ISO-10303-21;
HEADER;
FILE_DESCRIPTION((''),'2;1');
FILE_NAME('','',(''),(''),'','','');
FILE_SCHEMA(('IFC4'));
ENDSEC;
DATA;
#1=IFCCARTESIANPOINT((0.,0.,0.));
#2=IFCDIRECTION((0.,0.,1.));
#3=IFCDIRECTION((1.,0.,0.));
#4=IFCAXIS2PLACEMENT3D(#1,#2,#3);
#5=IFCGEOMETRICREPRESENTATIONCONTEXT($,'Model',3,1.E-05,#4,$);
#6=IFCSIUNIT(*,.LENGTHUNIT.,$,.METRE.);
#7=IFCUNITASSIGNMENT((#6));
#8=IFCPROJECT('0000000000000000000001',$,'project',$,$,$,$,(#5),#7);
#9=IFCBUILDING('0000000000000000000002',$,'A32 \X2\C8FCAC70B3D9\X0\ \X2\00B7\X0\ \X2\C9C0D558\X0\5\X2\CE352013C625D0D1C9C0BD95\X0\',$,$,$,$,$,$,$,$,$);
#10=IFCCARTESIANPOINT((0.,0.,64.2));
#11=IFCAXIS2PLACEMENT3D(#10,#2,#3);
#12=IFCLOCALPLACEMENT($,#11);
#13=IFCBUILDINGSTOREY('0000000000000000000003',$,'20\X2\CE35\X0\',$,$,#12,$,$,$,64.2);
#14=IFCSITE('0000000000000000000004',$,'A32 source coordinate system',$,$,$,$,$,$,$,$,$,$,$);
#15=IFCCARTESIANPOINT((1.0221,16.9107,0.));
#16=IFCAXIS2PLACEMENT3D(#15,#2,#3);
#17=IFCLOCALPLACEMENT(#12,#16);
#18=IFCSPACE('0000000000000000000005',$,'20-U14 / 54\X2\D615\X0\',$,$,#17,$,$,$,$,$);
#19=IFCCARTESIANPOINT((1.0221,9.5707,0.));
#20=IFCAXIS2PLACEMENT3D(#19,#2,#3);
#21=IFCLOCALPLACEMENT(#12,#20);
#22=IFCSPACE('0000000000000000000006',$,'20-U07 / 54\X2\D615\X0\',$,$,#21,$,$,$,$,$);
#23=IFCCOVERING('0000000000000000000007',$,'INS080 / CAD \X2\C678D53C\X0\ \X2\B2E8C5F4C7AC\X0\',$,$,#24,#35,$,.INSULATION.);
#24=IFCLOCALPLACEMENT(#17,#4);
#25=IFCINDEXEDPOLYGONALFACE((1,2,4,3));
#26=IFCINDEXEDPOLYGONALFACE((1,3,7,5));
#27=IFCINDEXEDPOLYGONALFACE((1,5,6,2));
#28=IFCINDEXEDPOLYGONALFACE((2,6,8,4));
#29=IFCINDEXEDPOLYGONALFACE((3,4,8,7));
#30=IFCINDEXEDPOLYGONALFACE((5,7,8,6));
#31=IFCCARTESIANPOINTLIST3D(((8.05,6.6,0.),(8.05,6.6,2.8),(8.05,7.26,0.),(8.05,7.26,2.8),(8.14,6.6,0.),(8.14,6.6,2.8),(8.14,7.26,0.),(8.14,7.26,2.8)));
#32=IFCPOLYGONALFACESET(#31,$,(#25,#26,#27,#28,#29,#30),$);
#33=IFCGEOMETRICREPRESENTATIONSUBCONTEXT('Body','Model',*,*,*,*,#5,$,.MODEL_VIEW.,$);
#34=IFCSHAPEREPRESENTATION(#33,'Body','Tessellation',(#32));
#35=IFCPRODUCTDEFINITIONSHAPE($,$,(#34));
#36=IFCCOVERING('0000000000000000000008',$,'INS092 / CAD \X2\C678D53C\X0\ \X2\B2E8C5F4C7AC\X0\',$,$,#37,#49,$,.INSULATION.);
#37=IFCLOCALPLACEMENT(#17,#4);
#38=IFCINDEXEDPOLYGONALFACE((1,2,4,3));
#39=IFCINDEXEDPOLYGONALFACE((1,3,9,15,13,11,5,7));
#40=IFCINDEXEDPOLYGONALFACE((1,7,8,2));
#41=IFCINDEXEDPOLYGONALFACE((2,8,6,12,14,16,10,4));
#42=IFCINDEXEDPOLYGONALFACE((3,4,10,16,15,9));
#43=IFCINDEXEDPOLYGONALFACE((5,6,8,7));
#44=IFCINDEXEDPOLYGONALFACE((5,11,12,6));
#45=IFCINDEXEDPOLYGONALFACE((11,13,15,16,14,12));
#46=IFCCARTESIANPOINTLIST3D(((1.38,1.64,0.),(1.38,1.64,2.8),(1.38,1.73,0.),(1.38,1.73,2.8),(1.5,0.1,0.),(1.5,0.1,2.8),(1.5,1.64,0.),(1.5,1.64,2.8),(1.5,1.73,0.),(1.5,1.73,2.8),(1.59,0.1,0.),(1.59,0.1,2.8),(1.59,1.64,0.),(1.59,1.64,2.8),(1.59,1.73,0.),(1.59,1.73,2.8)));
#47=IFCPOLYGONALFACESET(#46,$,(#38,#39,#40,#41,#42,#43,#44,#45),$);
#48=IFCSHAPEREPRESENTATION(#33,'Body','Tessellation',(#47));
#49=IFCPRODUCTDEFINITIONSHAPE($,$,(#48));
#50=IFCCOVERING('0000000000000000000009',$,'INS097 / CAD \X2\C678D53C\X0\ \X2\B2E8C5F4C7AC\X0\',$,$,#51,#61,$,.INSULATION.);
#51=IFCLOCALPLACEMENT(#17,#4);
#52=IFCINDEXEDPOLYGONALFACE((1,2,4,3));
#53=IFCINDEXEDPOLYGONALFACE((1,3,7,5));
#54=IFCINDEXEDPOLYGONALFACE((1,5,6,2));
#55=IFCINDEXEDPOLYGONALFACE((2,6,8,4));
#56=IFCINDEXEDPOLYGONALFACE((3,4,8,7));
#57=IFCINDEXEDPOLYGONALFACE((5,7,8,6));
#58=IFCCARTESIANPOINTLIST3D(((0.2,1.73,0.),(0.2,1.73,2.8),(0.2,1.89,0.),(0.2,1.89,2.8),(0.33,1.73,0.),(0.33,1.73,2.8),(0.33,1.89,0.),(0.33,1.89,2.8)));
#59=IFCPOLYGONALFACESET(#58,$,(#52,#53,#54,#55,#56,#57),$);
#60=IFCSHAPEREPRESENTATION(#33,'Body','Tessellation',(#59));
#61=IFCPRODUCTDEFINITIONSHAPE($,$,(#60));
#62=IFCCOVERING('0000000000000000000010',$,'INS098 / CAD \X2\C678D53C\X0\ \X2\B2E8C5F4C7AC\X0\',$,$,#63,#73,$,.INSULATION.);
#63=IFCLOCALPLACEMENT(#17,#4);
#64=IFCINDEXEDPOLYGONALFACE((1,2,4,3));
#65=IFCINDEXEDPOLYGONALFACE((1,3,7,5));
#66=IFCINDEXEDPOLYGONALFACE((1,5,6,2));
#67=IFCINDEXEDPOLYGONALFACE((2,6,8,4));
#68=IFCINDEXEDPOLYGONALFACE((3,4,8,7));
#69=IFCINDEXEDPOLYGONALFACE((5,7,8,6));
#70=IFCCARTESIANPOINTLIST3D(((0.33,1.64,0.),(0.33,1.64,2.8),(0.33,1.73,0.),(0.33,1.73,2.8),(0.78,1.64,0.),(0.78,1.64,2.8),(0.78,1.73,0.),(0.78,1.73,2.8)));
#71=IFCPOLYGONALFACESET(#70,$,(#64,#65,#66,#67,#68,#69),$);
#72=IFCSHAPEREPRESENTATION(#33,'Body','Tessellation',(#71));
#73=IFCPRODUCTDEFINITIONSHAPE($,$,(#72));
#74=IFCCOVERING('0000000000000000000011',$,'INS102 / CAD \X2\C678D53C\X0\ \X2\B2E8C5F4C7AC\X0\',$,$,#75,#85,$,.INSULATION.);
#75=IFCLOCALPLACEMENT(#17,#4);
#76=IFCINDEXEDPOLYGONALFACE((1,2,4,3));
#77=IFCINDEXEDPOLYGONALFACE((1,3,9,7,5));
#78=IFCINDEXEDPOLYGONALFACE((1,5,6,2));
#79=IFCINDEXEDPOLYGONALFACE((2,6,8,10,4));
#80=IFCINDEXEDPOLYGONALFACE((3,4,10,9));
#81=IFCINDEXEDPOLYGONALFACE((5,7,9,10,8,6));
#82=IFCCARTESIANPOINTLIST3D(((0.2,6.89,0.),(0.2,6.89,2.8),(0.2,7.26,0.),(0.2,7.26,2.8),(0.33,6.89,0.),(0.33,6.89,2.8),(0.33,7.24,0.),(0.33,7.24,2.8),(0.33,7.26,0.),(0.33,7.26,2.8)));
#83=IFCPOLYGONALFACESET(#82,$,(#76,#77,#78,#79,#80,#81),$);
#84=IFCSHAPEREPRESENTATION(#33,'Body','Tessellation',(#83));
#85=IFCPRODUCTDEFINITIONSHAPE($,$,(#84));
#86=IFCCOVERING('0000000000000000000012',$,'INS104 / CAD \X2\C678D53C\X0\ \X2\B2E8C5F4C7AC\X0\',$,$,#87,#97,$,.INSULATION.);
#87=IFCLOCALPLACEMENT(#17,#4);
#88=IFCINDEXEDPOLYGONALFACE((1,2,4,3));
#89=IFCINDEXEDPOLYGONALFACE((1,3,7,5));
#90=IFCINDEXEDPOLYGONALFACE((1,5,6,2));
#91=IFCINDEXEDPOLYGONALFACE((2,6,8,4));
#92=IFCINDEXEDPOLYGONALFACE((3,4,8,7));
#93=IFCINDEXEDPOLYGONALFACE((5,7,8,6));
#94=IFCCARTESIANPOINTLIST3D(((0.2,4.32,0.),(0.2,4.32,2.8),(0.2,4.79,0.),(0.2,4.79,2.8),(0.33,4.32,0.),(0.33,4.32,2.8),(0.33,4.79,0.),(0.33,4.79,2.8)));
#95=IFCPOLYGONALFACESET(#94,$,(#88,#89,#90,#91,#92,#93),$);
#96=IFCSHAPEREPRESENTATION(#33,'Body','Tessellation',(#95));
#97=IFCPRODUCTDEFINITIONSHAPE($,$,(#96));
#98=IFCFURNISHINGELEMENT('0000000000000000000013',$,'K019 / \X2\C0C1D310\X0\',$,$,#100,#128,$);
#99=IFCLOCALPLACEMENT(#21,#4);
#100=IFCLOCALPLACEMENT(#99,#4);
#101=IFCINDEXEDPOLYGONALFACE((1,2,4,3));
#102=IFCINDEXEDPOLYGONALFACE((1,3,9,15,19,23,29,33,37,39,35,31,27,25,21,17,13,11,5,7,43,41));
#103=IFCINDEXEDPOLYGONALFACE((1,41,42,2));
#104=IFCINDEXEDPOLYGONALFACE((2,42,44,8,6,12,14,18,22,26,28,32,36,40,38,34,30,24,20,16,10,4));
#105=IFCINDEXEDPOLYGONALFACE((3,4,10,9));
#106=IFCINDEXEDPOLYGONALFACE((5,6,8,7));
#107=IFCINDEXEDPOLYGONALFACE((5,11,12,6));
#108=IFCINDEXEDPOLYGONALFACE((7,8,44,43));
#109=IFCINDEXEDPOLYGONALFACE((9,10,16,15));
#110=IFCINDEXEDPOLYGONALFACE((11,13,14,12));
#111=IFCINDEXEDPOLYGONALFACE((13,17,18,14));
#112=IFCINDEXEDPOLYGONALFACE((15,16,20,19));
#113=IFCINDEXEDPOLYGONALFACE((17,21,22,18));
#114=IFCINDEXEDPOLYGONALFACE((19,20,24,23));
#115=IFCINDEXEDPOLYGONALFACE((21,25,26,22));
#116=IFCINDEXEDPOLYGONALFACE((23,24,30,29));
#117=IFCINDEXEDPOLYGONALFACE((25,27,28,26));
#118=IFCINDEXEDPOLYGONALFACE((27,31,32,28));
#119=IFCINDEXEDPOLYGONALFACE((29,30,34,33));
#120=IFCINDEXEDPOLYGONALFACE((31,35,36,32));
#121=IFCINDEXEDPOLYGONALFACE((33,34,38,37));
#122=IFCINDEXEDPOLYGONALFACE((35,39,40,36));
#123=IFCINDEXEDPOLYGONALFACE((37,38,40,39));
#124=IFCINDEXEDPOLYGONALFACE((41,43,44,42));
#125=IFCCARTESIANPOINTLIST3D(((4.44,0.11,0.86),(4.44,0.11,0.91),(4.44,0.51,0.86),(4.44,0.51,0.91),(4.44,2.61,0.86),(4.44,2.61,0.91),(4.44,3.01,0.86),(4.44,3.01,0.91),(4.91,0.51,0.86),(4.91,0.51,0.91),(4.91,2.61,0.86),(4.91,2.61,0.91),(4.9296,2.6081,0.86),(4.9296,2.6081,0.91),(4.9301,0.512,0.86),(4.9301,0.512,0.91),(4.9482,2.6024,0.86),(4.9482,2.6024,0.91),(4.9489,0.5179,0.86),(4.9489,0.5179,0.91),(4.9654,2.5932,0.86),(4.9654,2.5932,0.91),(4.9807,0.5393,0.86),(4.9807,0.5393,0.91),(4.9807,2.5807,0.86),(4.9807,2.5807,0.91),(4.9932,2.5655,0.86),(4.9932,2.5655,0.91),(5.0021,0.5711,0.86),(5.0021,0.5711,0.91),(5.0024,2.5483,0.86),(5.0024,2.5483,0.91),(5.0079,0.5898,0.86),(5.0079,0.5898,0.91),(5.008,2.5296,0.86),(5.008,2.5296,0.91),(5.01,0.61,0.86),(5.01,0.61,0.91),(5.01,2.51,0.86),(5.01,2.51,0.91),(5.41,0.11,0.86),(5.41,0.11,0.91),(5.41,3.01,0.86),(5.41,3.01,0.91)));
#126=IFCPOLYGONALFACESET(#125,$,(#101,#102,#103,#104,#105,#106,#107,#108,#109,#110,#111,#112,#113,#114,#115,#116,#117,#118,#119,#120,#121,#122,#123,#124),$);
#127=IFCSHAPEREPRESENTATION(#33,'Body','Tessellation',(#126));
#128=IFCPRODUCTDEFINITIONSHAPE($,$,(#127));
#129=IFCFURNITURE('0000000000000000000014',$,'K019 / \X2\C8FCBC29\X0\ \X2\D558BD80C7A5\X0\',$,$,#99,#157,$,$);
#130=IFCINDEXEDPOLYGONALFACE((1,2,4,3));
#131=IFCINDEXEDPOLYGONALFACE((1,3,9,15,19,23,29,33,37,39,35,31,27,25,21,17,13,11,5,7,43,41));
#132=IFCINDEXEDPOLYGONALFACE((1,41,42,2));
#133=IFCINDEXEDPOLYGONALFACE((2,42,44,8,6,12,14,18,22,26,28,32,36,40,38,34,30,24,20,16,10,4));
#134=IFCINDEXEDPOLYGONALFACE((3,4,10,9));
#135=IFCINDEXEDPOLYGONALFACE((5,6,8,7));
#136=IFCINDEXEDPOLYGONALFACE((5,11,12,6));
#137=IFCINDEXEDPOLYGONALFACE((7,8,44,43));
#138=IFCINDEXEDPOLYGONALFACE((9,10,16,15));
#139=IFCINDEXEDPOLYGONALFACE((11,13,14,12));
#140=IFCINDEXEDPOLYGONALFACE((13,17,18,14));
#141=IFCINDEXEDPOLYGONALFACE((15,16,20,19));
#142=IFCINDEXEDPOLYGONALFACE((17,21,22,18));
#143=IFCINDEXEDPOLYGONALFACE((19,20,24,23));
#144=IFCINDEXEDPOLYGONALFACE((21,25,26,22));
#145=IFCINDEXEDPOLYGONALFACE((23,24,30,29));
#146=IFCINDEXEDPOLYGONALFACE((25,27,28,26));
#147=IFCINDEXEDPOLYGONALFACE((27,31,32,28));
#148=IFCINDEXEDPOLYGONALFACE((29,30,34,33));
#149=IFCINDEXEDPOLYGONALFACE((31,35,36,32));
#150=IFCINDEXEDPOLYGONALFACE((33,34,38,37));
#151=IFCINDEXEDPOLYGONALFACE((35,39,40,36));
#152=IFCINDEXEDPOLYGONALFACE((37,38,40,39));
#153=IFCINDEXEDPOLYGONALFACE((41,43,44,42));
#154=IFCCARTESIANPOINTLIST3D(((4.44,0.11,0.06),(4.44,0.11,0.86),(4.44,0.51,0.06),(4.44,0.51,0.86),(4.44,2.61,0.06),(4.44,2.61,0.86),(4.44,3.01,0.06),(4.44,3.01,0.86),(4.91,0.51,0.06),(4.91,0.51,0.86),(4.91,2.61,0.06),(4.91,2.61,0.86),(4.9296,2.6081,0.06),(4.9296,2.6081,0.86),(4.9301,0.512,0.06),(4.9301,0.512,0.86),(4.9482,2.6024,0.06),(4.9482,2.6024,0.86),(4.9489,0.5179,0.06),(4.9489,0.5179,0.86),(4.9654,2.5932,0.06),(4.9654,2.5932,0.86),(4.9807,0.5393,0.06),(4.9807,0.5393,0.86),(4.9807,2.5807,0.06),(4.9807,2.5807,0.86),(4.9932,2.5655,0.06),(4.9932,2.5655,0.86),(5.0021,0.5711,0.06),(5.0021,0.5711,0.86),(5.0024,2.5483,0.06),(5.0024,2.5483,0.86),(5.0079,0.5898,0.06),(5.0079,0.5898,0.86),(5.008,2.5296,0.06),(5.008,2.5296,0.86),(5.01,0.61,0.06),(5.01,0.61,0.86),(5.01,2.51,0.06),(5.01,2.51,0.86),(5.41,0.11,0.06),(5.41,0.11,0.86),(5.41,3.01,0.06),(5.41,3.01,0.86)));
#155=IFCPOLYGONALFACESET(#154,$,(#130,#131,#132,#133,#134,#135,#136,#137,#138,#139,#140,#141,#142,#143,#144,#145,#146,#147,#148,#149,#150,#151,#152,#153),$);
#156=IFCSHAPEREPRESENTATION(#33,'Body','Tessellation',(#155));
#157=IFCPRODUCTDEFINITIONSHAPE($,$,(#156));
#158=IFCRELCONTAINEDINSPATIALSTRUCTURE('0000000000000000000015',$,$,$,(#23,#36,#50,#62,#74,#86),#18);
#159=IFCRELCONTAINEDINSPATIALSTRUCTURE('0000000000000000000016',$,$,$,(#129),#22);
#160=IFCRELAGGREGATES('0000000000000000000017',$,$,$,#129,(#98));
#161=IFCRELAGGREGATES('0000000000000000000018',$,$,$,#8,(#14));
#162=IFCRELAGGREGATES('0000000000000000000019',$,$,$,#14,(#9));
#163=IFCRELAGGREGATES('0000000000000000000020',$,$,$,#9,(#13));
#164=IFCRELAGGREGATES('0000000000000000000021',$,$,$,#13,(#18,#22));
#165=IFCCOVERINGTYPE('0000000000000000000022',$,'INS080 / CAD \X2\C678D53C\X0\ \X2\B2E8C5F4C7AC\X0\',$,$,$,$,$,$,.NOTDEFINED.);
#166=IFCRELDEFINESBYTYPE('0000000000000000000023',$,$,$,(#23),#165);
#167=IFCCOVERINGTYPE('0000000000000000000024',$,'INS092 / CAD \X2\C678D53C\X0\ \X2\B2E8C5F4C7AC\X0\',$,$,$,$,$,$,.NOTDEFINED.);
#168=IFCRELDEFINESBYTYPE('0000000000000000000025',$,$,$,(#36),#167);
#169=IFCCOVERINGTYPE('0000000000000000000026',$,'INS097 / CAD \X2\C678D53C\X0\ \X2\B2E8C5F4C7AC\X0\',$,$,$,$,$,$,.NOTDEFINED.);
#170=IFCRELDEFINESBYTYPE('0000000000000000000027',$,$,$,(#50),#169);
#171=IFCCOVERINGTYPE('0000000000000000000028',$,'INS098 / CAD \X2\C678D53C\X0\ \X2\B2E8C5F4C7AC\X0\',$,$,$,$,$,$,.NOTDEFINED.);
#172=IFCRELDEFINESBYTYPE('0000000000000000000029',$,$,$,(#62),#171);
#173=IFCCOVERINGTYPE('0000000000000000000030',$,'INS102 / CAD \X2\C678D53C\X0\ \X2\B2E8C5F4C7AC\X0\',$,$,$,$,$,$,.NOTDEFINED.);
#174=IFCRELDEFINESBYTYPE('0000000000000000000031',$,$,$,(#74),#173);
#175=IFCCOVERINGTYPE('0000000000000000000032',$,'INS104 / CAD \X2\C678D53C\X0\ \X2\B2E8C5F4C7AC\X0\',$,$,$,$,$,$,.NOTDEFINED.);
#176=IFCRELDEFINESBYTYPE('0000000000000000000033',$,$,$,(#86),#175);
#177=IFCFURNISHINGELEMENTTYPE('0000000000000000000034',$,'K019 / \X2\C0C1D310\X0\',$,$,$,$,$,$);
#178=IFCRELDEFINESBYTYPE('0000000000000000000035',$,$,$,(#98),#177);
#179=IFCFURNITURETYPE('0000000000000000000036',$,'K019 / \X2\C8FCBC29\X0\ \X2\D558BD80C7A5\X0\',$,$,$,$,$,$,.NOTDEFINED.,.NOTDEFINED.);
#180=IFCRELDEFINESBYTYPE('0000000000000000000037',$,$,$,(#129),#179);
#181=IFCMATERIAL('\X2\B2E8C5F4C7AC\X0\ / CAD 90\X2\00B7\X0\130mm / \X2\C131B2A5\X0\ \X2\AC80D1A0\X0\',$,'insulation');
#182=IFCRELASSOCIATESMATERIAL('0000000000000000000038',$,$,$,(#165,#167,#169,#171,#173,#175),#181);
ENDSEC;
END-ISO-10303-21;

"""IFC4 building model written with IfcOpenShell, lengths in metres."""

from ifc_helpers import new_model, si_unit, frame, origin, origin_with_axes, place, context, subcontext, project, spatial, polyline, outline, extrude, source, transform, mapped, material, type_object, type_shapes, element, aggregate, save


model = new_model("IFC4")

# Units and contexts
model_context = context("Model", 3, precision=1e-05, world=origin_with_axes())
body_context = subcontext(model_context, "Body", "Model", "MODEL_VIEW")
ifc_project = project(units=[si_unit("LENGTHUNIT", "METRE")], contexts=[model_context])

# Site, building, storey, space
storey_placement = place(None, frame((0.0, 0.0, 64.2), z_axis=(0.0, 0.0, 1.0), x_axis=(1.0, 0.0, 0.0)))
space_1_placement = place(storey_placement, frame((1.0221, 16.9107, 0.0), z_axis=(0.0, 0.0, 1.0), x_axis=(1.0, 0.0, 0.0)))
site = spatial("IfcSite", under=ifc_project, Name="A32 source coordinate system")
building = spatial("IfcBuilding", under=site, Name="A32 주거동 · 지하5층–옥탑지붕")
storey = spatial("IfcBuildingStorey", under=building, at=storey_placement, Name="20층", Elevation=64.2)
space_1 = spatial("IfcSpace", under=storey, at=space_1_placement, Name="20-U14 / 54형")

# Coverings
ifc_material = material(Name="단열재 / CAD 90·130mm / 성능 검토", Category="insulation")
covering_type_1 = type_object("IfcCoveringType", Name="INS080 / CAD 외피 단열재", PredefinedType="NOTDEFINED", material=ifc_material)
shared_shape_1 = source(origin(), body_context, "Body", "SweptSolid", [
    extrude(outline(polyline([(8.14, 7.26), (8.14, 6.6), (8.05, 6.6), (8.05, 7.26), (8.14, 7.26)])), origin(), (0.0, 0.0, 1.0), 2.8),
])
type_shapes(covering_type_1, [shared_shape_1])
covering_1_placement = place(space_1_placement, origin_with_axes())
element("IfcCovering", 1, at=covering_1_placement, inside=space_1, type_object=covering_type_1, Name="INS080 / CAD 외피 단열재", PredefinedType="INSULATION", context=body_context, shape_type="MappedRepresentation", body=[
    mapped(shared_shape_1, transform((0.0, 0.0, 0.0), scale=1.0)),
])
covering_type_2 = type_object("IfcCoveringType", Name="INS092 / CAD 외피 단열재", PredefinedType="NOTDEFINED", material=ifc_material)
shared_shape_2 = source(origin(), body_context, "Body", "SweptSolid", [
    extrude(outline(polyline([(1.59, 1.73), (1.59, 1.64), (1.59, 0.1), (1.5, 0.1), (1.5, 1.64), (1.38, 1.64), (1.38, 1.73), (1.5, 1.73), (1.59, 1.73)])), origin(), (0.0, 0.0, 1.0), 2.8),
])
type_shapes(covering_type_2, [shared_shape_2])
covering_2_placement = place(space_1_placement, origin_with_axes())
element("IfcCovering", 2, at=covering_2_placement, inside=space_1, type_object=covering_type_2, Name="INS092 / CAD 외피 단열재", PredefinedType="INSULATION", context=body_context, shape_type="MappedRepresentation", body=[
    mapped(shared_shape_2, transform((0.0, 0.0, 0.0), scale=1.0)),
])
covering_type_3 = type_object("IfcCoveringType", Name="INS097 / CAD 외피 단열재", PredefinedType="NOTDEFINED", material=ifc_material)
shared_shape_3 = source(origin(), body_context, "Body", "SweptSolid", [
    extrude(outline(polyline([(0.33, 1.89), (0.33, 1.73), (0.2, 1.73), (0.2, 1.89), (0.33, 1.89)])), origin(), (0.0, 0.0, 1.0), 2.8),
])
type_shapes(covering_type_3, [shared_shape_3])
covering_3_placement = place(space_1_placement, origin_with_axes())
element("IfcCovering", 3, at=covering_3_placement, inside=space_1, type_object=covering_type_3, Name="INS097 / CAD 외피 단열재", PredefinedType="INSULATION", context=body_context, shape_type="MappedRepresentation", body=[
    mapped(shared_shape_3, transform((0.0, 0.0, 0.0), scale=1.0)),
])
covering_type_4 = type_object("IfcCoveringType", Name="INS098 / CAD 외피 단열재", PredefinedType="NOTDEFINED", material=ifc_material)
shared_shape_4 = source(origin(), body_context, "Body", "SweptSolid", [
    extrude(outline(polyline([(0.78, 1.73), (0.78, 1.64), (0.33, 1.64), (0.33, 1.73), (0.78, 1.73)])), origin(), (0.0, 0.0, 1.0), 2.8),
])
type_shapes(covering_type_4, [shared_shape_4])
covering_4_placement = place(space_1_placement, origin_with_axes())
element("IfcCovering", 4, at=covering_4_placement, inside=space_1, type_object=covering_type_4, Name="INS098 / CAD 외피 단열재", PredefinedType="INSULATION", context=body_context, shape_type="MappedRepresentation", body=[
    mapped(shared_shape_4, transform((0.0, 0.0, 0.0), scale=1.0)),
])
covering_type_5 = type_object("IfcCoveringType", Name="INS102 / CAD 외피 단열재", PredefinedType="NOTDEFINED", material=ifc_material)
shared_shape_5 = source(origin(), body_context, "Body", "SweptSolid", [
    extrude(outline(polyline([(0.33, 7.26), (0.33, 7.24), (0.33, 6.89), (0.2, 6.89), (0.2, 7.26), (0.33, 7.26)])), origin(), (0.0, 0.0, 1.0), 2.8),
])
type_shapes(covering_type_5, [shared_shape_5])
covering_5_placement = place(space_1_placement, origin_with_axes())
element("IfcCovering", 5, at=covering_5_placement, inside=space_1, type_object=covering_type_5, Name="INS102 / CAD 외피 단열재", PredefinedType="INSULATION", context=body_context, shape_type="MappedRepresentation", body=[
    mapped(shared_shape_5, transform((0.0, 0.0, 0.0), scale=1.0)),
])
covering_type_6 = type_object("IfcCoveringType", Name="INS104 / CAD 외피 단열재", PredefinedType="NOTDEFINED", material=ifc_material)
shared_shape_6 = source(origin(), body_context, "Body", "SweptSolid", [
    extrude(outline(polyline([(0.33, 4.32), (0.2, 4.32), (0.2, 4.79), (0.33, 4.79), (0.33, 4.32)])), origin(), (0.0, 0.0, 1.0), 2.8),
])
type_shapes(covering_type_6, [shared_shape_6])
covering_6_placement = place(space_1_placement, origin_with_axes())
element("IfcCovering", 6, at=covering_6_placement, inside=space_1, type_object=covering_type_6, Name="INS104 / CAD 외피 단열재", PredefinedType="INSULATION", context=body_context, shape_type="MappedRepresentation", body=[
    mapped(shared_shape_6, transform((0.0, 0.0, 0.0), scale=1.0)),
])

# Furnishing element
furnishing_element_type = type_object("IfcFurnishingElementType", Name="K019 / 상판")
shared_shape_7 = source(origin(), body_context, "Body", "SweptSolid", [
    extrude(outline(polyline([(4.91, 0.51), (4.9301, 0.512), (4.9489, 0.5179), (4.9807, 0.5393), (5.0021, 0.5711), (5.0079, 0.5898), (5.01, 0.61), (5.01, 2.51), (5.008, 2.5296), (5.0024, 2.5483), (4.9932, 2.5655), (4.9807, 2.5807), (4.9654, 2.5932), (4.9482, 2.6024), (4.9296, 2.6081), (4.91, 2.61), (4.44, 2.61), (4.44, 3.01), (5.41, 3.01), (5.41, 0.11), (4.44, 0.11), (4.44, 0.51), (4.91, 0.51)])), frame((0.0, 0.0, 0.86)), (0.0, 0.0, 1.0), 0.05),
])
type_shapes(furnishing_element_type, [shared_shape_7])
space_2_placement = place(storey_placement, frame((1.0221, 9.5707, 0.0), z_axis=(0.0, 0.0, 1.0), x_axis=(1.0, 0.0, 0.0)))
furniture_placement = place(space_2_placement, origin_with_axes())
furnishing_placement = place(furniture_placement, origin_with_axes())
furnishing = element("IfcFurnishingElement", 7, at=furnishing_placement, type_object=furnishing_element_type, Name="K019 / 상판", context=body_context, shape_type="MappedRepresentation", body=[
    mapped(shared_shape_7, transform((0.0, 0.0, 0.0), scale=1.0)),
])

# Shared definitions
space_2 = spatial("IfcSpace", under=storey, at=space_2_placement, Name="20-U07 / 54형")

# Furniture
furniture_type = type_object("IfcFurnitureType", Name="K019 / 주방 하부장", AssemblyPlace="NOTDEFINED", PredefinedType="NOTDEFINED")
shared_shape_8 = source(origin(), body_context, "Body", "SweptSolid", [
    extrude(outline(polyline([(4.44, 0.51), (4.91, 0.51), (4.9301, 0.512), (4.9489, 0.5179), (4.9807, 0.5393), (5.0021, 0.5711), (5.0079, 0.5898), (5.01, 0.61), (5.01, 2.51), (5.008, 2.5296), (5.0024, 2.5483), (4.9932, 2.5655), (4.9807, 2.5807), (4.9654, 2.5932), (4.9482, 2.6024), (4.9296, 2.6081), (4.91, 2.61), (4.44, 2.61), (4.44, 3.01), (5.41, 3.01), (5.41, 0.11), (4.44, 0.11), (4.44, 0.51)])), frame((0.0, 0.0, 0.06)), (0.0, 0.0, 1.0), 0.8),
])
type_shapes(furniture_type, [shared_shape_8])
furniture = element("IfcFurniture", 8, at=furniture_placement, inside=space_2, type_object=furniture_type, Name="K019 / 주방 하부장", context=body_context, shape_type="MappedRepresentation", body=[
    mapped(shared_shape_8, transform((0.0, 0.0, 0.0), scale=1.0)),
])
aggregate(furniture, [furnishing])

save(model, "model.ifc")
